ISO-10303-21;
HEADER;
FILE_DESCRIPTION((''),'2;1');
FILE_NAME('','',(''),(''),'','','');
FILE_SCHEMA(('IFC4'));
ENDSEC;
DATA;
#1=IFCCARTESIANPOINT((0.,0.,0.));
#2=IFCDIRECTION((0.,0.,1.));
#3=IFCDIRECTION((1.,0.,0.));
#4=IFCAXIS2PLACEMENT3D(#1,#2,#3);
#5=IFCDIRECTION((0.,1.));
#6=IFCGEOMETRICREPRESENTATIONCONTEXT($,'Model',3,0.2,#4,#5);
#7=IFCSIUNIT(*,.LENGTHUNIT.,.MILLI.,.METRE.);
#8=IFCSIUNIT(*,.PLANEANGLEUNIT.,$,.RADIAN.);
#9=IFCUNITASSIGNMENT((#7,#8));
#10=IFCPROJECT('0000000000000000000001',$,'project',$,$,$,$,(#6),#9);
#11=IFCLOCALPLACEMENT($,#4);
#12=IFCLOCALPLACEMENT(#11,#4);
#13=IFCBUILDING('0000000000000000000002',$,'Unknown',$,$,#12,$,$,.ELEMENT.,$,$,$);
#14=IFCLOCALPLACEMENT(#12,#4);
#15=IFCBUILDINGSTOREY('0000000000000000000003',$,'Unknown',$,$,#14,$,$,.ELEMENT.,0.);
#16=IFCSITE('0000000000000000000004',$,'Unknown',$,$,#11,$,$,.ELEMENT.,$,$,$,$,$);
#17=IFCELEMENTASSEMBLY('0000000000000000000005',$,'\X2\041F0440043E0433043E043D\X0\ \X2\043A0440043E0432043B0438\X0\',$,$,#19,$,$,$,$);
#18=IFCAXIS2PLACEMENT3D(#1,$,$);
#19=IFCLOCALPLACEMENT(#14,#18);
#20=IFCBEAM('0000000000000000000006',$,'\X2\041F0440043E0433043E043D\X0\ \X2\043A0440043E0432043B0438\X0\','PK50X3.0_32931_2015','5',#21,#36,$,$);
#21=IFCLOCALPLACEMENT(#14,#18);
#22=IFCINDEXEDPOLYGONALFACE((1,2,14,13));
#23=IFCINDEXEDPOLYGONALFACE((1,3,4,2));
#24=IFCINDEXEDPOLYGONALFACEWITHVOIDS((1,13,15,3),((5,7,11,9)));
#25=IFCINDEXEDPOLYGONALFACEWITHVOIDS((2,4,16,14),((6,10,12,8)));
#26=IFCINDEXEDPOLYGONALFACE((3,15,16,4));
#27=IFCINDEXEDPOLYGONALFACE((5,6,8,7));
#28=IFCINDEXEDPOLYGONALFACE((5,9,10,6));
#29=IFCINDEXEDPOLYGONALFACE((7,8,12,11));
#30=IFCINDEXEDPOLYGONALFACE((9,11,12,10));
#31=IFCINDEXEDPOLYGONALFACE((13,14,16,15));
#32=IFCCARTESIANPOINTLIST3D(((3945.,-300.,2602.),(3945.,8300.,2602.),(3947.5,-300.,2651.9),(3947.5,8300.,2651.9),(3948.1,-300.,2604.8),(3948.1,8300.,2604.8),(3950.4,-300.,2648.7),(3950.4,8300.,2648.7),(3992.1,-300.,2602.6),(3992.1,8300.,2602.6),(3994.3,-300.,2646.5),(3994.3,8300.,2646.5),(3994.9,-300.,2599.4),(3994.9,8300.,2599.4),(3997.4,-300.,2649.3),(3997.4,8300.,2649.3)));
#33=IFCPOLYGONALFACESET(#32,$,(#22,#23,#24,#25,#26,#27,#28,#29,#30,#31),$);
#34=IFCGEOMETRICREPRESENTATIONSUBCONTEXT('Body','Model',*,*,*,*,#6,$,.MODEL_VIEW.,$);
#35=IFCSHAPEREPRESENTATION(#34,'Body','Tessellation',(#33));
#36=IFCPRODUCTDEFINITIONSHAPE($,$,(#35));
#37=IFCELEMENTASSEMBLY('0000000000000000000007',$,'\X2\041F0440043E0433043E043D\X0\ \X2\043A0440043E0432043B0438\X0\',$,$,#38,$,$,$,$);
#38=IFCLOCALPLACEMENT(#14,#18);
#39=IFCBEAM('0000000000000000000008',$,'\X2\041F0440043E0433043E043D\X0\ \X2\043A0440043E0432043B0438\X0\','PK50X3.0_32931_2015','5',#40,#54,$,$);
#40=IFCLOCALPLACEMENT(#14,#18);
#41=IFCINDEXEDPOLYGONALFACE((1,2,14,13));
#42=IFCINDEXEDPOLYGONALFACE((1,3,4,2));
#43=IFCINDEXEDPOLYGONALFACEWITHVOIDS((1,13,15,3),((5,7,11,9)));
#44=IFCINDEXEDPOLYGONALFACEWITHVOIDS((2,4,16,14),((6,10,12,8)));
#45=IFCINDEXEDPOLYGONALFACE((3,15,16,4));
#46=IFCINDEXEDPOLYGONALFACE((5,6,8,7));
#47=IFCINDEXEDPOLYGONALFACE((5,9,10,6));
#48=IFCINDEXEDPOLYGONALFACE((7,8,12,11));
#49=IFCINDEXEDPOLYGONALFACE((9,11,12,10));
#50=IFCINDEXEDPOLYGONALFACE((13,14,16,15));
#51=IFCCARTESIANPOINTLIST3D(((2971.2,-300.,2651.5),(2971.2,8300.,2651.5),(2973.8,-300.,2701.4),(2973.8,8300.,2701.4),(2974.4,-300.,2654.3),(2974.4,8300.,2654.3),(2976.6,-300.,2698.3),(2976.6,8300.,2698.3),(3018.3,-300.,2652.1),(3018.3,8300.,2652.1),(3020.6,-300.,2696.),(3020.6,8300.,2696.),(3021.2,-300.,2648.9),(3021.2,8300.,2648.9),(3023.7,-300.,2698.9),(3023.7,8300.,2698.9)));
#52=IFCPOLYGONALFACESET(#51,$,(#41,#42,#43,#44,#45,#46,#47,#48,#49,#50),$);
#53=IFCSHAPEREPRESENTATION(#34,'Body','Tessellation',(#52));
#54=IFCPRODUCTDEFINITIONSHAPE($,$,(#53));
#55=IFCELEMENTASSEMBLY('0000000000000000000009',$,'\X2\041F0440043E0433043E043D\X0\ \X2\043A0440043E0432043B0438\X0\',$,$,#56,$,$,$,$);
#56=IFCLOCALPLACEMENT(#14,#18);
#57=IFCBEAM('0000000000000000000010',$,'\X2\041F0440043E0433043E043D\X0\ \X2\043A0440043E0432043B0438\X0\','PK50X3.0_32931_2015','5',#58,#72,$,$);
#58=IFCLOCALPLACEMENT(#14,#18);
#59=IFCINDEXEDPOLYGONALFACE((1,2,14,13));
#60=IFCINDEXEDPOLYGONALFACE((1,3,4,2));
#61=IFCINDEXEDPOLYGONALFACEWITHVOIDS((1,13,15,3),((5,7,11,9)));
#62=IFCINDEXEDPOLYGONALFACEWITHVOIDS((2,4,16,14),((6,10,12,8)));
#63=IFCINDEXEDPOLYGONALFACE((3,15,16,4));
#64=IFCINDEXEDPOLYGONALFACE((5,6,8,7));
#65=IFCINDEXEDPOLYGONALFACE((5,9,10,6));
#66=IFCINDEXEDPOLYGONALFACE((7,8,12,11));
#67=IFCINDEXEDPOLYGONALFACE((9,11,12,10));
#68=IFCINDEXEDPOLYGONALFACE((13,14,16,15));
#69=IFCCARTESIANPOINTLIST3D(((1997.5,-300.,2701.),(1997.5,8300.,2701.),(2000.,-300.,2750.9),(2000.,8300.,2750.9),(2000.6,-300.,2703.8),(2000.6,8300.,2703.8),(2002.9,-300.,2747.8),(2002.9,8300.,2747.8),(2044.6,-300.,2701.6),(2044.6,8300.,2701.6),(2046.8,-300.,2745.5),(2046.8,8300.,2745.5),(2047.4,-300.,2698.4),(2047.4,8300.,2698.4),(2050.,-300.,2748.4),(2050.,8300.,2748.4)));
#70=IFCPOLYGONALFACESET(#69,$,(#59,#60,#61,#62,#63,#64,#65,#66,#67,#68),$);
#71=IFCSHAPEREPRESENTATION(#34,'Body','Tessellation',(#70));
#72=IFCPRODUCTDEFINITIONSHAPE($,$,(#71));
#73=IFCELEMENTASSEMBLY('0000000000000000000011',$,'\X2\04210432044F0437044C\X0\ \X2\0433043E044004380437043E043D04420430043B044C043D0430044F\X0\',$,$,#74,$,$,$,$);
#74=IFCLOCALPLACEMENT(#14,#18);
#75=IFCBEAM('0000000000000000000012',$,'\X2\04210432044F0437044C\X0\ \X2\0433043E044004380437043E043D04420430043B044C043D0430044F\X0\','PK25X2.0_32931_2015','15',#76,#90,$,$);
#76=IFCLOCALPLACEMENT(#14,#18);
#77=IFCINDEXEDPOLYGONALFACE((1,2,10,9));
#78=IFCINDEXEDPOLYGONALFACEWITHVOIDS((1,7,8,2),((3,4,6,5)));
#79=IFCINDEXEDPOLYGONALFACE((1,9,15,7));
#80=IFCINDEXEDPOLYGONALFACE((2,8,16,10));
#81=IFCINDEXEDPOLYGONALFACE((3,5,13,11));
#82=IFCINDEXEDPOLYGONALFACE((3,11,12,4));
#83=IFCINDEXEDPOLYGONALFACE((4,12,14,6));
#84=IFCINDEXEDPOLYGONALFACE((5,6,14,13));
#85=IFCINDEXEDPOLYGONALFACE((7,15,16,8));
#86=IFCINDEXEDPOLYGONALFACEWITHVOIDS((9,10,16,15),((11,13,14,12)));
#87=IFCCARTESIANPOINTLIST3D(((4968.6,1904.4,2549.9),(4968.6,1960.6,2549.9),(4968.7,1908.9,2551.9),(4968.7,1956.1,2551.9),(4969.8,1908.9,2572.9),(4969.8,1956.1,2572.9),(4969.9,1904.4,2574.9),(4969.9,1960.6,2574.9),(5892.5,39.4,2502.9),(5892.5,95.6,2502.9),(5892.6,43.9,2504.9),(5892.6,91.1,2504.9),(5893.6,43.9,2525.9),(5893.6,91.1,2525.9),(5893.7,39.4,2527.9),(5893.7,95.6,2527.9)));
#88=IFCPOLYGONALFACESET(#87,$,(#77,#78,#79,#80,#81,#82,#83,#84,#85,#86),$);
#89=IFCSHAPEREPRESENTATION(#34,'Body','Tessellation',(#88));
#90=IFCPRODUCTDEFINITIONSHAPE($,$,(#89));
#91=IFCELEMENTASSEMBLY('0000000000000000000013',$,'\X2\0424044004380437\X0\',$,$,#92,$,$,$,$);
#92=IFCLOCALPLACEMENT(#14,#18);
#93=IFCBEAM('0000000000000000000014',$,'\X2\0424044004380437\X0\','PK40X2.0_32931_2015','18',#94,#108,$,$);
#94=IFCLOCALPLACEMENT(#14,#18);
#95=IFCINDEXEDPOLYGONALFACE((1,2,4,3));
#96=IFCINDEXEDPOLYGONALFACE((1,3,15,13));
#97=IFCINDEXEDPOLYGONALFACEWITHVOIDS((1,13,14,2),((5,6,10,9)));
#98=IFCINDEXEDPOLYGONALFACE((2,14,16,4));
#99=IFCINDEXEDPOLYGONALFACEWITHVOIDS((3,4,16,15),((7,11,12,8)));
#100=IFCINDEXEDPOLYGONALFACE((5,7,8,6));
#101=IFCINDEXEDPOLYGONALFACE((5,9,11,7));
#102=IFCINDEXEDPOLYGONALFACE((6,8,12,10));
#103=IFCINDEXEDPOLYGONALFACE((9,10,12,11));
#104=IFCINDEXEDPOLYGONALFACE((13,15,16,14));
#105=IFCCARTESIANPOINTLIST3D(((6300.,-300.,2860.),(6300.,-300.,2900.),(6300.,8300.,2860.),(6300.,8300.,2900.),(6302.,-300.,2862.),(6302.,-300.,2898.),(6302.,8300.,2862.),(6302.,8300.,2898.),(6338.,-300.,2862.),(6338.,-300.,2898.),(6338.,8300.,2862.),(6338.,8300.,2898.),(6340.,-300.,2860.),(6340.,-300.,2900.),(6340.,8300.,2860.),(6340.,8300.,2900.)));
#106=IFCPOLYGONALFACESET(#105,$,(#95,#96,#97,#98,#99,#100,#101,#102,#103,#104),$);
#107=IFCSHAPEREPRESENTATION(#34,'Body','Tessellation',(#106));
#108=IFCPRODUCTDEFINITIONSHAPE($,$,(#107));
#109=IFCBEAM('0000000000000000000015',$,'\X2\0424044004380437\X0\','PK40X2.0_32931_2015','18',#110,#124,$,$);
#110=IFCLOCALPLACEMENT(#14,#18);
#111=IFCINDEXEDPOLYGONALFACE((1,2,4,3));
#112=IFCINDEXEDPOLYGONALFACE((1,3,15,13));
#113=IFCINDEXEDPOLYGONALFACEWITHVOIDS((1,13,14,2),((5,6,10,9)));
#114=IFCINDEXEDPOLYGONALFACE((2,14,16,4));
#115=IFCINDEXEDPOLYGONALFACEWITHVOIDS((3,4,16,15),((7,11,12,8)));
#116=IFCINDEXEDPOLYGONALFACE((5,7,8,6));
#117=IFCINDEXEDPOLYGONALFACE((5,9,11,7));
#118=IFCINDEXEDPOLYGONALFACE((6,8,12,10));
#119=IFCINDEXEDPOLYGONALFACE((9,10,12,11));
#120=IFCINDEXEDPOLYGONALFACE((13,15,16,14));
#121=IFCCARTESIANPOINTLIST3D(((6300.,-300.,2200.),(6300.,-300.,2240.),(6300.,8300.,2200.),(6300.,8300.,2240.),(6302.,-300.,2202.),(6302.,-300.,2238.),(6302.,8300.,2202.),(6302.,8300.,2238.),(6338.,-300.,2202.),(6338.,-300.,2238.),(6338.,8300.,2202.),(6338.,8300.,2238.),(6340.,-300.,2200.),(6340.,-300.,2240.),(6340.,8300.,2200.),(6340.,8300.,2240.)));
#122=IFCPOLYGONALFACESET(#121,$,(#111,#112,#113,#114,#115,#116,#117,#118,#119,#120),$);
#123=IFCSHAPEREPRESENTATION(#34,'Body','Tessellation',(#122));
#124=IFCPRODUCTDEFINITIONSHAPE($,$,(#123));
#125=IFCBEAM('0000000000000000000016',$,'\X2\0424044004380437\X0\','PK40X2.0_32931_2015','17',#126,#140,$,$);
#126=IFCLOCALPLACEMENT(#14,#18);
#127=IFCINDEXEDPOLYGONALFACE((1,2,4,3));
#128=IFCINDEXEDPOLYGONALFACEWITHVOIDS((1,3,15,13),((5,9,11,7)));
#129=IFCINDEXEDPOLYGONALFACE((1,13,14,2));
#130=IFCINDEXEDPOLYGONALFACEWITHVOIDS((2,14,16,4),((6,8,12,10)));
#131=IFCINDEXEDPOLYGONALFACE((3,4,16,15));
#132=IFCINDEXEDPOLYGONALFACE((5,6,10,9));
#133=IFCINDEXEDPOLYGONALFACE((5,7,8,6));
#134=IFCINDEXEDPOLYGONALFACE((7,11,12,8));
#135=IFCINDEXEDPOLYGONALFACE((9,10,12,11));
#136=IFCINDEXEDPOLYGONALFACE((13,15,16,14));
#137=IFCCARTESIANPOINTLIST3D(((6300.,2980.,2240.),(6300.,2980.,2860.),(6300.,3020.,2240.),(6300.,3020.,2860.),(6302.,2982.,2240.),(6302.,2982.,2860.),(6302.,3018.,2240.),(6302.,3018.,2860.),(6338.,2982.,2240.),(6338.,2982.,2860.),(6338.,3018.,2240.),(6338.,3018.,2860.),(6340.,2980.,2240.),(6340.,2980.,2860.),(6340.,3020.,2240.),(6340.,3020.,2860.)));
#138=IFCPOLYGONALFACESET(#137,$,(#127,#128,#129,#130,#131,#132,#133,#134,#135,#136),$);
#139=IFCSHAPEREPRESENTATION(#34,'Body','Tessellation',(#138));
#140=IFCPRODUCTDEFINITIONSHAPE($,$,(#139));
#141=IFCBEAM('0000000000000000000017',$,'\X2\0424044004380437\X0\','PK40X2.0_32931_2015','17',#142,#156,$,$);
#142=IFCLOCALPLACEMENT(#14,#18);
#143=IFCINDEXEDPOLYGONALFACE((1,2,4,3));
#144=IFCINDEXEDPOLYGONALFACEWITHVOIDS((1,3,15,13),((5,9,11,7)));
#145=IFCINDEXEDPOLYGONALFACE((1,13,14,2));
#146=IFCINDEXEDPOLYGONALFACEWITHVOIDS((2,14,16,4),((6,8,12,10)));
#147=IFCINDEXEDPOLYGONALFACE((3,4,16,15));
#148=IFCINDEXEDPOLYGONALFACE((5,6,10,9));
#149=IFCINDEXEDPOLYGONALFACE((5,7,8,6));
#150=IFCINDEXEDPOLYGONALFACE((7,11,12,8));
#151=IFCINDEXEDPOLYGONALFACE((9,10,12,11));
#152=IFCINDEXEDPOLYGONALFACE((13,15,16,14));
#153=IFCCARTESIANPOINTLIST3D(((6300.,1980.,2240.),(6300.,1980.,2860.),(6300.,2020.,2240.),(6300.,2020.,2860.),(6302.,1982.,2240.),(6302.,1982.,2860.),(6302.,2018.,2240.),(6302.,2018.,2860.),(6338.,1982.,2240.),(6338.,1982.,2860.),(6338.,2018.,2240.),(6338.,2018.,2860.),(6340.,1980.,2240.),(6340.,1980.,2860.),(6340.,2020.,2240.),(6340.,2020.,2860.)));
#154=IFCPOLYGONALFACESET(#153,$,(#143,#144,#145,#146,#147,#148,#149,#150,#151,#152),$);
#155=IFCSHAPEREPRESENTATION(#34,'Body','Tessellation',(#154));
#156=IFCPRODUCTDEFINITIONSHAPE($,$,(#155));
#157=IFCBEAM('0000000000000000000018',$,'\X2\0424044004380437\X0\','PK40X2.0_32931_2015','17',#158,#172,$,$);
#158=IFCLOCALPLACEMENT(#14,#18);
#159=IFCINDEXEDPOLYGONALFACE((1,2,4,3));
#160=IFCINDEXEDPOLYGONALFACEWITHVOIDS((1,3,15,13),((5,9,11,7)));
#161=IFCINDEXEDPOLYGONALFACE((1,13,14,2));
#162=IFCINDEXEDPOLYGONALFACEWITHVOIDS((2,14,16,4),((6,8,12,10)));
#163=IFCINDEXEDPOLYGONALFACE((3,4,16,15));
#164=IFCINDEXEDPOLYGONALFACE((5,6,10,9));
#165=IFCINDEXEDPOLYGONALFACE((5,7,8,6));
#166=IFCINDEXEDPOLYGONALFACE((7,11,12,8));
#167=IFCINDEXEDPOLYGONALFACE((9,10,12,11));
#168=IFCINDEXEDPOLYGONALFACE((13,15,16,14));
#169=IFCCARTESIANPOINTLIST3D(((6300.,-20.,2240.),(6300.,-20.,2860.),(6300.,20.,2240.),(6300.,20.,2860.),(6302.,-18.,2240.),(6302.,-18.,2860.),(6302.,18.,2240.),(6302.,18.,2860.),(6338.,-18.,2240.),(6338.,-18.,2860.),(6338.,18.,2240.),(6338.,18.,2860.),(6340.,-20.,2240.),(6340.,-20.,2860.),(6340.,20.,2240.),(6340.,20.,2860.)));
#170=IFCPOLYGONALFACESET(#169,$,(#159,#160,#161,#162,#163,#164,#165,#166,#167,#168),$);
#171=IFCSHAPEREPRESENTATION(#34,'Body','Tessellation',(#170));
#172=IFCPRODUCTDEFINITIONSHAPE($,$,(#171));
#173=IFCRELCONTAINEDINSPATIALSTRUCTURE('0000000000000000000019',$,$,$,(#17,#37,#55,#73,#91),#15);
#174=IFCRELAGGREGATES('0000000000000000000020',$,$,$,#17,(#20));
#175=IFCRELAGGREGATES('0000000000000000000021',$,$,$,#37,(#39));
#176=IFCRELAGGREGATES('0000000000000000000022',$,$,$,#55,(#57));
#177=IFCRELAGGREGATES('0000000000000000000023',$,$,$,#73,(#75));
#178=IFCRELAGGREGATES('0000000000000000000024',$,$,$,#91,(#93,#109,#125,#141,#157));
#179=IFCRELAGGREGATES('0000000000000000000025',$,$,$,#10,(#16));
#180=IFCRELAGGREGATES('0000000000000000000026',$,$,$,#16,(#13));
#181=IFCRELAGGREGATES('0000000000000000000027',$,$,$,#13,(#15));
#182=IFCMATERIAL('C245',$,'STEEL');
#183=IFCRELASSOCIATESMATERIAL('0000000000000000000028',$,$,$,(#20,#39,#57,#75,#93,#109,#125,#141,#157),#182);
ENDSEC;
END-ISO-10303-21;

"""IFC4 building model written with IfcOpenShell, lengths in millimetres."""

from ifc_helpers import new_model, si_unit, direction, frame, origin_with_axes, place, context, subcontext, project, spatial, line, indexed_curve, outline, extrude, material, element, aggregate, save


model = new_model("IFC4")

# Units and contexts
model_context = context("Model", 3, precision=0.2, world=origin_with_axes(), true_north=direction((0.0, 1.0)))
body_context = subcontext(model_context, "Body", "Model", "MODEL_VIEW")
ifc_project = project(units=[si_unit("LENGTHUNIT", "METRE", prefix="MILLI"), si_unit("PLANEANGLEUNIT", "RADIAN")], contexts=[model_context])

# Site, building, storey
site_placement = place(None, origin_with_axes())
site = spatial("IfcSite", under=ifc_project, at=site_placement, Name="Unknown", CompositionType="ELEMENT")
building_placement = place(site_placement, origin_with_axes())
building = spatial("IfcBuilding", under=site, at=building_placement, Name="Unknown", CompositionType="ELEMENT")
storey_placement = place(building_placement, origin_with_axes())
storey = spatial("IfcBuildingStorey", under=building, at=storey_placement, Name="Unknown", CompositionType="ELEMENT", Elevation=0.0)

# Shared definitions
ifc_material_1 = material(Name="C245", Category="STEEL")

# Element assemblies, beams
assembly_1_placement = place(storey_placement, frame((3971.2, -300.0, 2625.6), z_axis=(0.99871, 0.0, -0.050782), x_axis=(0.0, 1.0, 0.0)))
assembly_1 = element("IfcElementAssembly", 1, at=assembly_1_placement, inside=storey, Name="Прогон кровли")
beam_1_placement = place(assembly_1_placement, origin_with_axes())
beam_1 = element("IfcBeam", 2, at=beam_1_placement, material=ifc_material_1, Name="Прогон кровли", Description="PK50X3.0_32931_2015", ObjectType="5", context=body_context, shape_type="SolidModel", body=[
    extrude(outline(indexed_curve([(-25.0, -25.0), (25.0, -25.0), (25.0, 25.0), (-25.0, 25.0)], segments=[line(1, 2, 3, 4, 1)]), holes=[indexed_curve([(-22.0, -22.0), (-22.0, 22.0), (22.0, 22.0), (22.0, -22.0)], segments=[line(1, 2, 3, 4, 1)])]), frame((0.0, 0.0, 0.0), z_axis=(-1.0, 0.0, 0.0), x_axis=(0.0, 0.0, 1.0)), (0.0, 0.0, -1.0), 8600.0),
])
aggregate(assembly_1, [beam_1])
assembly_2_placement = place(storey_placement, frame((2997.5, -300.0, 2675.2), z_axis=(0.99871, 0.0, -0.050782), x_axis=(0.0, 1.0, 0.0)))
assembly_2 = element("IfcElementAssembly", 3, at=assembly_2_placement, inside=storey, Name="Прогон кровли")
beam_2_placement = place(assembly_2_placement, origin_with_axes())
beam_2 = element("IfcBeam", 4, at=beam_2_placement, material=ifc_material_1, Name="Прогон кровли", Description="PK50X3.0_32931_2015", ObjectType="5", context=body_context, shape_type="SolidModel", body=[
    extrude(outline(indexed_curve([(-25.0, -25.0), (25.0, -25.0), (25.0, 25.0), (-25.0, 25.0)], segments=[line(1, 2, 3, 4, 1)]), holes=[indexed_curve([(-22.0, -22.0), (-22.0, 22.0), (22.0, 22.0), (22.0, -22.0)], segments=[line(1, 2, 3, 4, 1)])]), frame((0.0, 0.0, 0.0), z_axis=(-1.0, 0.0, 0.0), x_axis=(0.0, 0.0, 1.0)), (0.0, 0.0, -1.0), 8600.0),
])
aggregate(assembly_2, [beam_2])
assembly_3_placement = place(storey_placement, frame((2023.7, -300.0, 2724.7), z_axis=(0.99871, 0.0, -0.050782), x_axis=(0.0, 1.0, 0.0)))
assembly_3 = element("IfcElementAssembly", 5, at=assembly_3_placement, inside=storey, Name="Прогон кровли")
beam_3_placement = place(assembly_3_placement, origin_with_axes())
beam_3 = element("IfcBeam", 6, at=beam_3_placement, material=ifc_material_1, Name="Прогон кровли", Description="PK50X3.0_32931_2015", ObjectType="5", context=body_context, shape_type="SolidModel", body=[
    extrude(outline(indexed_curve([(-25.0, -25.0), (25.0, -25.0), (25.0, 25.0), (-25.0, 25.0)], segments=[line(1, 2, 3, 4, 1)]), holes=[indexed_curve([(-22.0, -22.0), (-22.0, 22.0), (22.0, 22.0), (22.0, -22.0)], segments=[line(1, 2, 3, 4, 1)])]), frame((0.0, 0.0, 0.0), z_axis=(-1.0, 0.0, 0.0), x_axis=(0.0, 0.0, 1.0)), (0.0, 0.0, -1.0), 8600.0),
])
aggregate(assembly_3, [beam_3])

# Element assembly, beam, voiding features
assembly_4_placement = place(storey_placement, frame((5920.3, 12.6, 2514.0), z_axis=(0.894709, 0.444326, -0.045494), x_axis=(-0.443753, 0.895865, 0.022564)))
assembly_4 = element("IfcElementAssembly", 7, at=assembly_4_placement, inside=storey, Name="Связь горизонтальная")
beam_4_placement = place(assembly_4_placement, origin_with_axes())
beam_4 = element("IfcBeam", 8, at=beam_4_placement, material=ifc_material_1, Name="Связь горизонтальная", Description="PK25X2.0_32931_2015", ObjectType="15", context=body_context, shape_type="SolidModel", body=[
    extrude(outline(indexed_curve([(-12.5, -12.5), (12.5, -12.5), (12.5, 12.5), (-12.5, 12.5)], segments=[line(1, 2, 3, 4, 1)]), holes=[indexed_curve([(-10.5, -10.5), (-10.5, 10.5), (10.5, 10.5), (10.5, -10.5)], segments=[line(1, 2, 3, 4, 1)])]), frame((0.0, 0.0, 0.0), z_axis=(-1.0, 0.0, 0.0), x_axis=(0.0, 0.0, 1.0)), (0.0, 0.0, -1.0), 2204.4),
])
voiding_feature_1_placement = place(beam_4_placement, frame((1204.9, 12.5, -493.2), z_axis=(-0.444326, 0.0, 0.895865), x_axis=(0.895865, 0.0, 0.444326)))
element("IfcVoidingFeature", 9, at=voiding_feature_1_placement, cuts=beam_4, Name="CUT_BEAM", ObjectType="(?)", PredefinedType="HOLE", context=body_context, shape_type="SolidModel", body=[
    extrude(outline(indexed_curve([(-25.0, -25.0), (25.0, -25.0), (25.0, 25.0), (-25.0, 25.0)], segments=[line(1, 2, 3, 4, 1)])), frame((0.0, 0.0, 0.0), z_axis=(-1.0, 0.0, 0.0), x_axis=(0.0, 0.0, 1.0)), (0.0, 0.0, -1.0), 2220.1),
])
voiding_feature_2_placement = place(beam_4_placement, frame((-989.4, 12.5, -493.2), z_axis=(-0.444326, 0.0, 0.895865), x_axis=(0.895865, 0.0, 0.444326)))
element("IfcVoidingFeature", 10, at=voiding_feature_2_placement, cuts=beam_4, Name="CUT_BEAM", ObjectType="(?)", PredefinedType="HOLE", context=body_context, shape_type="SolidModel", body=[
    extrude(outline(indexed_curve([(-25.0, -25.0), (25.0, -25.0), (25.0, 25.0), (-25.0, 25.0)], segments=[line(1, 2, 3, 4, 1)])), frame((0.0, 0.0, 0.0), z_axis=(-1.0, 0.0, 0.0), x_axis=(0.0, 0.0, 1.0)), (0.0, 0.0, -1.0), 2220.1),
])
aggregate(assembly_4, [beam_4])

# Element assembly, beams
assembly_5_placement = place(storey_placement, frame((6320.0, -300.0, 2880.0), z_axis=(1.0, 0.0, 0.0), x_axis=(0.0, 1.0, 0.0)))
assembly_5 = element("IfcElementAssembly", 11, at=assembly_5_placement, inside=storey, Name="Фриз")
beam_5_placement = place(assembly_5_placement, origin_with_axes())
beam_5 = element("IfcBeam", 12, at=beam_5_placement, material=ifc_material_1, Name="Фриз", Description="PK40X2.0_32931_2015", ObjectType="18", context=body_context, shape_type="SolidModel", body=[
    extrude(outline(indexed_curve([(-20.0, -20.0), (20.0, -20.0), (20.0, 20.0), (-20.0, 20.0)], segments=[line(1, 2, 3, 4, 1)]), holes=[indexed_curve([(-18.0, -18.0), (-18.0, 18.0), (18.0, 18.0), (18.0, -18.0)], segments=[line(1, 2, 3, 4, 1)])]), frame((0.0, 0.0, 0.0), z_axis=(-1.0, 0.0, 0.0), x_axis=(0.0, 0.0, 1.0)), (0.0, 0.0, -1.0), 8600.0),
])
beam_6_placement = place(assembly_5_placement, frame((0.0, -660.0, 0.0), z_axis=(0.0, 0.0, 1.0), x_axis=(1.0, 0.0, 0.0)))
beam_6 = element("IfcBeam", 13, at=beam_6_placement, material=ifc_material_1, Name="Фриз", Description="PK40X2.0_32931_2015", ObjectType="18", context=body_context, shape_type="SolidModel", body=[
    extrude(outline(indexed_curve([(-20.0, -20.0), (20.0, -20.0), (20.0, 20.0), (-20.0, 20.0)], segments=[line(1, 2, 3, 4, 1)]), holes=[indexed_curve([(-18.0, -18.0), (-18.0, 18.0), (18.0, 18.0), (18.0, -18.0)], segments=[line(1, 2, 3, 4, 1)])]), frame((0.0, 0.0, 0.0), z_axis=(-1.0, 0.0, 0.0), x_axis=(0.0, 0.0, 1.0)), (0.0, 0.0, -1.0), 8600.0),
])
beam_7_placement = place(assembly_5_placement, frame((3300.0, -20.0, 0.0), z_axis=(1.0, 0.0, 0.0), x_axis=(0.0, -1.0, 0.0)))
beam_7 = element("IfcBeam", 14, at=beam_7_placement, material=ifc_material_1, Name="Фриз", Description="PK40X2.0_32931_2015", ObjectType="17", context=body_context, shape_type="SolidModel", body=[
    extrude(outline(indexed_curve([(-20.0, -20.0), (20.0, -20.0), (20.0, 20.0), (-20.0, 20.0)], segments=[line(1, 2, 3, 4, 1)]), holes=[indexed_curve([(-18.0, -18.0), (-18.0, 18.0), (18.0, 18.0), (18.0, -18.0)], segments=[line(1, 2, 3, 4, 1)])]), frame((0.0, 0.0, 0.0), z_axis=(-1.0, 0.0, 0.0), x_axis=(0.0, 0.0, 1.0)), (0.0, 0.0, -1.0), 620.0),
])
beam_8_placement = place(assembly_5_placement, frame((2300.0, -20.0, 0.0), z_axis=(1.0, 0.0, 0.0), x_axis=(0.0, -1.0, 0.0)))
beam_8 = element("IfcBeam", 15, at=beam_8_placement, material=ifc_material_1, Name="Фриз", Description="PK40X2.0_32931_2015", ObjectType="17", context=body_context, shape_type="SolidModel", body=[
    extrude(outline(indexed_curve([(-20.0, -20.0), (20.0, -20.0), (20.0, 20.0), (-20.0, 20.0)], segments=[line(1, 2, 3, 4, 1)]), holes=[indexed_curve([(-18.0, -18.0), (-18.0, 18.0), (18.0, 18.0), (18.0, -18.0)], segments=[line(1, 2, 3, 4, 1)])]), frame((0.0, 0.0, 0.0), z_axis=(-1.0, 0.0, 0.0), x_axis=(0.0, 0.0, 1.0)), (0.0, 0.0, -1.0), 620.0),
])
beam_9_placement = place(assembly_5_placement, frame((300.0, -20.0, 0.0), z_axis=(1.0, 0.0, 0.0), x_axis=(0.0, -1.0, 0.0)))
beam_9 = element("IfcBeam", 16, at=beam_9_placement, material=ifc_material_1, Name="Фриз", Description="PK40X2.0_32931_2015", ObjectType="17", context=body_context, shape_type="SolidModel", body=[
    extrude(outline(indexed_curve([(-20.0, -20.0), (20.0, -20.0), (20.0, 20.0), (-20.0, 20.0)], segments=[line(1, 2, 3, 4, 1)]), holes=[indexed_curve([(-18.0, -18.0), (-18.0, 18.0), (18.0, 18.0), (18.0, -18.0)], segments=[line(1, 2, 3, 4, 1)])]), frame((0.0, 0.0, 0.0), z_axis=(-1.0, 0.0, 0.0), x_axis=(0.0, 0.0, 1.0)), (0.0, 0.0, -1.0), 620.0),
])
aggregate(assembly_5, [beam_5, beam_6, beam_7, beam_8, beam_9])

save(model, "model.ifc")
